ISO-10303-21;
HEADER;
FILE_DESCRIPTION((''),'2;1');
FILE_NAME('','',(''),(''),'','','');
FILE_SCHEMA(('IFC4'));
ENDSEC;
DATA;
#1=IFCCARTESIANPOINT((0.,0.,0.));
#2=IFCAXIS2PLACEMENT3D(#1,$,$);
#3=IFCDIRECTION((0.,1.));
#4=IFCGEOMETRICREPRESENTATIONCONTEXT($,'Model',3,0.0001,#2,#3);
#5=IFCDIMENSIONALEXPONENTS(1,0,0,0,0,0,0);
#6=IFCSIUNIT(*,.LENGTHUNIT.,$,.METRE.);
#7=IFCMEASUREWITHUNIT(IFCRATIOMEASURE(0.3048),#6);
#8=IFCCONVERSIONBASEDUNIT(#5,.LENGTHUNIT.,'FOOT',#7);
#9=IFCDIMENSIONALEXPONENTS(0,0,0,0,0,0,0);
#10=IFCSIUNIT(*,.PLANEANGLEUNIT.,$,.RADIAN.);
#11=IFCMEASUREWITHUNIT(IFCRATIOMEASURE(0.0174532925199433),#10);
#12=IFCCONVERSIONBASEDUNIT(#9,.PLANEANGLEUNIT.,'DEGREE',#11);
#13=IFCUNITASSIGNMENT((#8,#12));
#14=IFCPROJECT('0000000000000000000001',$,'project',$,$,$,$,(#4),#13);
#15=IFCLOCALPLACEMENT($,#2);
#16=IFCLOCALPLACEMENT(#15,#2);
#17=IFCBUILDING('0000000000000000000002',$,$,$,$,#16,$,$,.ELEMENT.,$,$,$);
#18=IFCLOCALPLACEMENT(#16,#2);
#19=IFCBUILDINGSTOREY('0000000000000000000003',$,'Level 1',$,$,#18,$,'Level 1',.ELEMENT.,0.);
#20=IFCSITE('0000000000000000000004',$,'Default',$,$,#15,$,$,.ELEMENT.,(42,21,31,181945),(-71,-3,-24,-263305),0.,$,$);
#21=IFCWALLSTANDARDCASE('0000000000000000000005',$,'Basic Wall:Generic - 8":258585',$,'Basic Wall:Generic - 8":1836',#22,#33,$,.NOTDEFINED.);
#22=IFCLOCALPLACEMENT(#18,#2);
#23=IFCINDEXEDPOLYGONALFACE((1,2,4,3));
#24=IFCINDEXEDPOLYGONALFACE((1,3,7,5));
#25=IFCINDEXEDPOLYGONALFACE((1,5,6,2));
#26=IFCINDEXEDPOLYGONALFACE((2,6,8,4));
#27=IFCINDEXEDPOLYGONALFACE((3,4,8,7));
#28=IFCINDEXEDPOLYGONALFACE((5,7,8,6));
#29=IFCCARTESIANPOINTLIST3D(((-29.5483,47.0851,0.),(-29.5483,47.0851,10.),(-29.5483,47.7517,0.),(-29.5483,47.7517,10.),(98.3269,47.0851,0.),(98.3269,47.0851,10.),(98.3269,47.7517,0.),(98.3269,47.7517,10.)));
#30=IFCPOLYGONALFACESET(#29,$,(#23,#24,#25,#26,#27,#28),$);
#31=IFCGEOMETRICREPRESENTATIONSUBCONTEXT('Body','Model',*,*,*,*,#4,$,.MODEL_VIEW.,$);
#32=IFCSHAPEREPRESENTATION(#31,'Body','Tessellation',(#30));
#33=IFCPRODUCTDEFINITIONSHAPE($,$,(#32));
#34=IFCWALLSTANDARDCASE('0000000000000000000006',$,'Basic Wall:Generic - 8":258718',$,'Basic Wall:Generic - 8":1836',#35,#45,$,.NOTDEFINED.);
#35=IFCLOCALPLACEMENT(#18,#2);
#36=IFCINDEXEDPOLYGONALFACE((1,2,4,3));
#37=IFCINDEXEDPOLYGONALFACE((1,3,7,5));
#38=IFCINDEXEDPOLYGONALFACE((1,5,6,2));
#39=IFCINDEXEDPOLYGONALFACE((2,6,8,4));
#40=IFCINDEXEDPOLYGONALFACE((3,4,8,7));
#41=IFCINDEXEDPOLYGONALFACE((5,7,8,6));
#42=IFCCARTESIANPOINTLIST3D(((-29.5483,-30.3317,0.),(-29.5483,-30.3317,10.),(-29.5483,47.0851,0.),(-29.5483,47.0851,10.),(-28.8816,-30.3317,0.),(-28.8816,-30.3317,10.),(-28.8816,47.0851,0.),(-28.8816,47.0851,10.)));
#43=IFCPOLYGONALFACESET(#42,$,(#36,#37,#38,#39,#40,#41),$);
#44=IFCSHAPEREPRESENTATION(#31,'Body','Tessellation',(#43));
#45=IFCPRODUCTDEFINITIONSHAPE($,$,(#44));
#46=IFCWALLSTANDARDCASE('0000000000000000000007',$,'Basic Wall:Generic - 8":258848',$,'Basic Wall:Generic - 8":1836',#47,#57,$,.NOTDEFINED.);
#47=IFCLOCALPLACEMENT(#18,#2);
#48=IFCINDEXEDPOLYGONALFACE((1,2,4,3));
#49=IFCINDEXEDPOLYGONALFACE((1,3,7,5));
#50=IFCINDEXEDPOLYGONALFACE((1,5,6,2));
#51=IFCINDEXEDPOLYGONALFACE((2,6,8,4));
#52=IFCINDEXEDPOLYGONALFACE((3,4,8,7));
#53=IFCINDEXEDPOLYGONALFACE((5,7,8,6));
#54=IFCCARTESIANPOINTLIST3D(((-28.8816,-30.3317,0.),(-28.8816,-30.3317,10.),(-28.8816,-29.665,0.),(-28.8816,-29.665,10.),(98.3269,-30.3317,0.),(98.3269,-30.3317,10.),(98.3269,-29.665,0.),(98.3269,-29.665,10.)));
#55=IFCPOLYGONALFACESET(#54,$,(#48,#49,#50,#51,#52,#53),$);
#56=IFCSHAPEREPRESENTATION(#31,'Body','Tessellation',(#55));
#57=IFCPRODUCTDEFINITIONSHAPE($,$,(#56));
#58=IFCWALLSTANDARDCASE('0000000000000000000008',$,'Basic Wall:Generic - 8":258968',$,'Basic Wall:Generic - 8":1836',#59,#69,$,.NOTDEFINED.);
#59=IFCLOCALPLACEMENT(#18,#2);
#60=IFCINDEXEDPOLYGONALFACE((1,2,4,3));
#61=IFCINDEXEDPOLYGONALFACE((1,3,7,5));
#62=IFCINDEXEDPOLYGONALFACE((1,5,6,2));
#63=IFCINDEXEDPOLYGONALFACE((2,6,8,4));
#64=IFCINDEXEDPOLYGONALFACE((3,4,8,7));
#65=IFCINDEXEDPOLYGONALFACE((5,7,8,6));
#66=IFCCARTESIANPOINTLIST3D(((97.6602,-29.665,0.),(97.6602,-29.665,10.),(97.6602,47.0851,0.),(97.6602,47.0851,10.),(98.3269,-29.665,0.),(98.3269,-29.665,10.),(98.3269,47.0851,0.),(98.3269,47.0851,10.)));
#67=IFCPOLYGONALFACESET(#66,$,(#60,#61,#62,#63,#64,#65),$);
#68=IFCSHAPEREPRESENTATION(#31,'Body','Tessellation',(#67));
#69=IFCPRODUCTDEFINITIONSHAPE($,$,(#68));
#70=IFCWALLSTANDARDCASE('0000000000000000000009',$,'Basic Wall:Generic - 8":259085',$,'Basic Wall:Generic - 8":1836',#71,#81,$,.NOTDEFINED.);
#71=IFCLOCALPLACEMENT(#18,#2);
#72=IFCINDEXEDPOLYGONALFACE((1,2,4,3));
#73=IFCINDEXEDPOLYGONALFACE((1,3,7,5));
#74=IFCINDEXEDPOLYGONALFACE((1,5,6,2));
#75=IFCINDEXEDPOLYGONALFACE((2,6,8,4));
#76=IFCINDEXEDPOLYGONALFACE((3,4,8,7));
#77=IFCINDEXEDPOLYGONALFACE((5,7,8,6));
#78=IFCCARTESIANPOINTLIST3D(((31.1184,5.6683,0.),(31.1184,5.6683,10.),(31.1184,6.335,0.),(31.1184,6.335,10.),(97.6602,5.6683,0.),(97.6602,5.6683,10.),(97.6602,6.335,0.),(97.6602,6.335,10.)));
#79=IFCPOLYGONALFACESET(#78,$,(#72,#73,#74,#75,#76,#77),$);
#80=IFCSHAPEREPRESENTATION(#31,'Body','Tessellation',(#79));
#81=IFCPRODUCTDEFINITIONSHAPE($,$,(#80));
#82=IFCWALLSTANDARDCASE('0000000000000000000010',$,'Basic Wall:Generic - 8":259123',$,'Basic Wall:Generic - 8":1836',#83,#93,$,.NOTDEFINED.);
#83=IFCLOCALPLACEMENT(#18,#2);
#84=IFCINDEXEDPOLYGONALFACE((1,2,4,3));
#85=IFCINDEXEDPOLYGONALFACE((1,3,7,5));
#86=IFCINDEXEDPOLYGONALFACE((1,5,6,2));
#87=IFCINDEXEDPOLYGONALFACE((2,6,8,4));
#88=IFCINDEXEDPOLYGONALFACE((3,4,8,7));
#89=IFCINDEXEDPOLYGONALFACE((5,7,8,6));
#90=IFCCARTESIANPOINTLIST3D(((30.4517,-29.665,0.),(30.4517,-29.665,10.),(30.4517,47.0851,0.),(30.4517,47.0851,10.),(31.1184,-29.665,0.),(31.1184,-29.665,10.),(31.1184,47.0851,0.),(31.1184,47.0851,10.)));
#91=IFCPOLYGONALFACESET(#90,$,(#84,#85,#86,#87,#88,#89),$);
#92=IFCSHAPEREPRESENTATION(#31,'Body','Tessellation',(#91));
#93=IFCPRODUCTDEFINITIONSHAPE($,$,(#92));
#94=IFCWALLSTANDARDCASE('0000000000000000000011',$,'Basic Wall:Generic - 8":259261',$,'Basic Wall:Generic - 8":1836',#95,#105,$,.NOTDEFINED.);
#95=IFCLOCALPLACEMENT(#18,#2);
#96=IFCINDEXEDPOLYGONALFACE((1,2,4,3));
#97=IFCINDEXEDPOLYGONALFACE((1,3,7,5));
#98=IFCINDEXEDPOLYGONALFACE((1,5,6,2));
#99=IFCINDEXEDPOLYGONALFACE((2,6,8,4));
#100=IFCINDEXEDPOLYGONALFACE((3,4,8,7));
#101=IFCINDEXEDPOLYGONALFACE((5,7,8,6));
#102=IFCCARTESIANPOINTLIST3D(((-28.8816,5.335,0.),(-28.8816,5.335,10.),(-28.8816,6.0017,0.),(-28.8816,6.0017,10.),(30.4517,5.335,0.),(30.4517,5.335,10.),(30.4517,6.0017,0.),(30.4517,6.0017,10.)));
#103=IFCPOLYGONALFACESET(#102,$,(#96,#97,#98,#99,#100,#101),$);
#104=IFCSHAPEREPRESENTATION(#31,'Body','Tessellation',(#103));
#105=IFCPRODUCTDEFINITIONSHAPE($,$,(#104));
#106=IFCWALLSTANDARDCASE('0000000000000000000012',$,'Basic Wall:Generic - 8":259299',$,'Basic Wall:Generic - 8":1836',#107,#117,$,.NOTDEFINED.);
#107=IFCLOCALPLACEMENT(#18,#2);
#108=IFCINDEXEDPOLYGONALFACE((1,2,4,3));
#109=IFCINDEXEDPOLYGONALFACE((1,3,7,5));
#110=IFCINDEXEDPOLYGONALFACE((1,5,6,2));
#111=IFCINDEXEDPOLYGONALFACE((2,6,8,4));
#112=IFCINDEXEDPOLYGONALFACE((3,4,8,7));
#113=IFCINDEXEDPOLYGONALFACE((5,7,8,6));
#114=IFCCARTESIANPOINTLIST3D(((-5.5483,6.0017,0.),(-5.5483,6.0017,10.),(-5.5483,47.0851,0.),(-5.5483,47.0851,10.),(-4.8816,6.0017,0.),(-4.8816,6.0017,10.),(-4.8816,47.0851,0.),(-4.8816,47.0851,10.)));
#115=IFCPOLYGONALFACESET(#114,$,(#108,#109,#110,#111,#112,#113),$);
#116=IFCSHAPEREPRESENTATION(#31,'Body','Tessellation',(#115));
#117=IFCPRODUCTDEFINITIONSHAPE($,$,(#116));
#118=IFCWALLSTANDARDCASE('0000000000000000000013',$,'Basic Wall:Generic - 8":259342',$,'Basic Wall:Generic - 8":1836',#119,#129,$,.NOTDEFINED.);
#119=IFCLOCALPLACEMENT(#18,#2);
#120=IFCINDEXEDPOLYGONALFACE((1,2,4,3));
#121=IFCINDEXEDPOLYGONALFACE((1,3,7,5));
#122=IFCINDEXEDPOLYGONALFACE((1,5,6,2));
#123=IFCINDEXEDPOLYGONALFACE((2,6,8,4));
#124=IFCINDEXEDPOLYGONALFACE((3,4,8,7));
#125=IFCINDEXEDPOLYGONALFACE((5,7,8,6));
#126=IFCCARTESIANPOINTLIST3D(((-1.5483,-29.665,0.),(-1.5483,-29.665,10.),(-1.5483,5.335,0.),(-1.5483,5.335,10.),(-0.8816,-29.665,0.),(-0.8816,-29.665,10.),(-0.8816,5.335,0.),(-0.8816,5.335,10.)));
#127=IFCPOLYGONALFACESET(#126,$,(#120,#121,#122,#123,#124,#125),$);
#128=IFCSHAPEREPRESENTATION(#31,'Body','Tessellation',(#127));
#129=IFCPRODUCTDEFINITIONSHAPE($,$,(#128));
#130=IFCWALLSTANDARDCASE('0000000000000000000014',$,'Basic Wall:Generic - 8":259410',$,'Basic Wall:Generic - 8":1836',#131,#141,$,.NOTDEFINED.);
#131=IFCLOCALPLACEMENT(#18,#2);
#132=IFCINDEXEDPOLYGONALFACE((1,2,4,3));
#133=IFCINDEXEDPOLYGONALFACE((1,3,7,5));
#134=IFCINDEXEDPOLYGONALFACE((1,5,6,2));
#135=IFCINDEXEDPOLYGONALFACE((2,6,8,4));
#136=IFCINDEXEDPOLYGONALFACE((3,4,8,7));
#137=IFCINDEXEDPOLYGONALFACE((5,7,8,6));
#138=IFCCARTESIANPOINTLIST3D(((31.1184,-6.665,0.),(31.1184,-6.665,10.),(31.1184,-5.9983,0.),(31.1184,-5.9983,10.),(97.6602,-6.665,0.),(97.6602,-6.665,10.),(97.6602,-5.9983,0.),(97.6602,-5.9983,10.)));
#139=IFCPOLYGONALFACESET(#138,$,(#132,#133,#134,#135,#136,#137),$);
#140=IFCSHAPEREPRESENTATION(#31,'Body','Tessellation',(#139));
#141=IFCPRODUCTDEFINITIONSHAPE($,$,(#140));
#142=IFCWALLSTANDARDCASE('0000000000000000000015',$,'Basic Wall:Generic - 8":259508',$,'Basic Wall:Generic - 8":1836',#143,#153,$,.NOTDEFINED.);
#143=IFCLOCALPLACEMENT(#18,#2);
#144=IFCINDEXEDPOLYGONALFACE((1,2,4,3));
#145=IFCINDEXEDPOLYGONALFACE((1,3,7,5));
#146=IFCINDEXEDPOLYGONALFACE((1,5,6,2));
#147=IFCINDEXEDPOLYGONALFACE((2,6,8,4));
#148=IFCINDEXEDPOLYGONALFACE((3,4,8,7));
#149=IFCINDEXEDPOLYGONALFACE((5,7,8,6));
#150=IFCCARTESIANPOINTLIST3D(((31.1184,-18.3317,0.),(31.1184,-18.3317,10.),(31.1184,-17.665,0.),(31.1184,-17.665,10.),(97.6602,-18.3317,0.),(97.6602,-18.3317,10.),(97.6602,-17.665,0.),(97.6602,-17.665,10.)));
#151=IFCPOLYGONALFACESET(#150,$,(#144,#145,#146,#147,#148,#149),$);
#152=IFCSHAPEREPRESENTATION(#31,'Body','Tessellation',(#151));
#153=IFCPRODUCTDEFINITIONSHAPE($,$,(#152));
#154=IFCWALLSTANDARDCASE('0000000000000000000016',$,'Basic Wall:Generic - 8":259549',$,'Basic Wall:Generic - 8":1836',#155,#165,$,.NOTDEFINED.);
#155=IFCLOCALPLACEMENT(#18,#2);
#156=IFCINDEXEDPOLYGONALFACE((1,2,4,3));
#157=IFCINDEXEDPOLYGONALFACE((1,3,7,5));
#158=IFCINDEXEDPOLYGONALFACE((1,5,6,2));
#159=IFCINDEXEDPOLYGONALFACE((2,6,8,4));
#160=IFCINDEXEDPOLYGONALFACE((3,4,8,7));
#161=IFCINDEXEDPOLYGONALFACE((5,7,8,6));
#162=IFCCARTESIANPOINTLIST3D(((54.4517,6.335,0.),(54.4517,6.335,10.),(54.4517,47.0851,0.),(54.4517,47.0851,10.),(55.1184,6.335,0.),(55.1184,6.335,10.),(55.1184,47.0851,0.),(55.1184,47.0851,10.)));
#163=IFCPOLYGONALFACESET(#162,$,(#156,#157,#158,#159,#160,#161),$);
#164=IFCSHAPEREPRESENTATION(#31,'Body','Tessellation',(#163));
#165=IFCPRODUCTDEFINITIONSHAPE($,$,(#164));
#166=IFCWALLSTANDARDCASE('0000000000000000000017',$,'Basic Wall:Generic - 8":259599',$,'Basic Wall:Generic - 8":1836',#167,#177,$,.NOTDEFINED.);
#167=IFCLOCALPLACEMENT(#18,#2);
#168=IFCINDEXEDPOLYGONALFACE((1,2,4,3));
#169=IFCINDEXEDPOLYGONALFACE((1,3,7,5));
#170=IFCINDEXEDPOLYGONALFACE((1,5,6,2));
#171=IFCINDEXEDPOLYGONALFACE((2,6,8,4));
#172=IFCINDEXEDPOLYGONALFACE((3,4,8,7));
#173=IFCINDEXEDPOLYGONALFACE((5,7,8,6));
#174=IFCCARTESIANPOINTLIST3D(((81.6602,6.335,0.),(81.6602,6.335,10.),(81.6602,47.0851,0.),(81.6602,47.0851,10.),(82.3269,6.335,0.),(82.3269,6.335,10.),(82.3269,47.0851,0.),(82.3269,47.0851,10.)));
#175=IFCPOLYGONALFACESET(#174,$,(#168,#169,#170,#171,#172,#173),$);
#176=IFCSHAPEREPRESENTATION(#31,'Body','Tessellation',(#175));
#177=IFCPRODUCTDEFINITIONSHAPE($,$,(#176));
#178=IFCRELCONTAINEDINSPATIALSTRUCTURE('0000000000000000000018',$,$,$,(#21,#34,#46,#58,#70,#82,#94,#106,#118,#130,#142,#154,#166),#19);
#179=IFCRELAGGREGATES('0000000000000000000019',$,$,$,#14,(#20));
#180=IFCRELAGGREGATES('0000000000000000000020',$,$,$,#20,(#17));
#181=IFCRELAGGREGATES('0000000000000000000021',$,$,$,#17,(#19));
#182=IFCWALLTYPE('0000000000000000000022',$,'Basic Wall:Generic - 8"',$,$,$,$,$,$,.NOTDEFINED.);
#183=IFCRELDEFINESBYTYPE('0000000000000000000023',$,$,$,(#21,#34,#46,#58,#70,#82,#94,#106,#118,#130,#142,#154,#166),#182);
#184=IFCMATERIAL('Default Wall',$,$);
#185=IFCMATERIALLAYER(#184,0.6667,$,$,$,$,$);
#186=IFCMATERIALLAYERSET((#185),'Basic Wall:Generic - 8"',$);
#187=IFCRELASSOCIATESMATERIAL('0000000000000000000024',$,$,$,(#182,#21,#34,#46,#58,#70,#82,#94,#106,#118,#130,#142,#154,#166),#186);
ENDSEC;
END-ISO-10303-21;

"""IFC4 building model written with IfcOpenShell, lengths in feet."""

from ifc_helpers import new_model, entity, si_unit, converted_unit, direction, frame, frame_2d, origin, place, context, subcontext, project, spatial, rectangle, extrude, material, layer, layer_set, layer_usage, type_object, element, save


model = new_model("IFC4")

# Units and contexts
model_context = context("Model", 3, precision=0.0001, world=origin(), true_north=direction((0.0, 1.0)))
body_context = subcontext(model_context, "Body", "Model", "MODEL_VIEW")
ifc_project = project(units=[converted_unit("LENGTHUNIT", "FOOT", entity("IfcRatioMeasure", 0.3048), si_unit("LENGTHUNIT", "METRE"), dimensions=[1, 0, 0, 0, 0, 0, 0]), converted_unit("PLANEANGLEUNIT", "DEGREE", entity("IfcRatioMeasure", 0.0174532925199433), si_unit("PLANEANGLEUNIT", "RADIAN"), dimensions=[0, 0, 0, 0, 0, 0, 0])], contexts=[model_context])

# Site, building, storey
site_placement = place(None, origin())
site = spatial("IfcSite", under=ifc_project, at=site_placement, Name="Default", CompositionType="ELEMENT", RefLatitude=(42, 21, 31, 181945), RefLongitude=(-71, -3, -24, -263305), RefElevation=0.0)
building_placement = place(site_placement, origin())
building = spatial("IfcBuilding", under=site, at=building_placement, CompositionType="ELEMENT")
storey_placement = place(building_placement, origin())
storey = spatial("IfcBuildingStorey", under=building, at=storey_placement, Name="Level 1", LongName="Level 1", CompositionType="ELEMENT", Elevation=0.0)

# Walls
ifc_material = material(Name="Default Wall")
ifc_layer = layer(ifc_material, 0.6667)
ifc_layer_set = layer_set([ifc_layer], Name="Basic Wall:Generic - 8\"")
ifc_layer_usage_1 = layer_usage(ifc_layer_set, "AXIS2", "NEGATIVE", 0.3333)
wall_type = type_object("IfcWallType", Name="Basic Wall:Generic - 8\"", PredefinedType="NOTDEFINED", material=ifc_layer_set)
wall_1_placement = place(storey_placement, frame((-29.5483, 47.4184, 0.0)))
element("IfcWallStandardCase", 1, at=wall_1_placement, inside=storey, type_object=wall_type, material=ifc_layer_usage_1, Name="Basic Wall:Generic - 8\":258585", ObjectType="Basic Wall:Generic - 8\":1836", PredefinedType="NOTDEFINED", context=body_context, shape_type="SweptSolid", body=[
    extrude(rectangle(XDim=127.8752, YDim=0.6667, at=frame_2d((63.9376, 0.0), x_axis=(-1.0, 0.0))), origin(), (0.0, 0.0, 1.0), 10.0),
])
ifc_layer_usage_2 = layer_usage(ifc_layer_set, "AXIS2", "NEGATIVE", 0.3333)
wall_2_placement = place(storey_placement, frame((-29.215, 47.0851, 0.0), z_axis=(0.0, 0.0, 1.0), x_axis=(0.0, -1.0, 0.0)))
element("IfcWallStandardCase", 2, at=wall_2_placement, inside=storey, type_object=wall_type, material=ifc_layer_usage_2, Name="Basic Wall:Generic - 8\":258718", ObjectType="Basic Wall:Generic - 8\":1836", PredefinedType="NOTDEFINED", context=body_context, shape_type="SweptSolid", body=[
    extrude(rectangle(XDim=77.4167, YDim=0.6667, at=frame_2d((38.7084, 0.0), x_axis=(-1.0, 0.0))), origin(), (0.0, 0.0, 1.0), 10.0),
])
ifc_layer_usage_3 = layer_usage(ifc_layer_set, "AXIS2", "NEGATIVE", 0.3333)
wall_3_placement = place(storey_placement, frame((-28.8816, -29.9983, 0.0)))
element("IfcWallStandardCase", 3, at=wall_3_placement, inside=storey, type_object=wall_type, material=ifc_layer_usage_3, Name="Basic Wall:Generic - 8\":258848", ObjectType="Basic Wall:Generic - 8\":1836", PredefinedType="NOTDEFINED", context=body_context, shape_type="SweptSolid", body=[
    extrude(rectangle(XDim=127.2085, YDim=0.6667, at=frame_2d((63.6043, 0.0), x_axis=(-1.0, 0.0))), origin(), (0.0, 0.0, 1.0), 10.0),
])
ifc_layer_usage_4 = layer_usage(ifc_layer_set, "AXIS2", "NEGATIVE", 0.3333)
wall_4_placement = place(storey_placement, frame((97.9936, -29.665, 0.0), z_axis=(0.0, 0.0, 1.0), x_axis=(0.0, 1.0, 0.0)))
element("IfcWallStandardCase", 4, at=wall_4_placement, inside=storey, type_object=wall_type, material=ifc_layer_usage_4, Name="Basic Wall:Generic - 8\":258968", ObjectType="Basic Wall:Generic - 8\":1836", PredefinedType="NOTDEFINED", context=body_context, shape_type="SweptSolid", body=[
    extrude(rectangle(XDim=76.7501, YDim=0.6667, at=frame_2d((38.375, 0.0), x_axis=(-1.0, 0.0))), origin(), (0.0, 0.0, 1.0), 10.0),
])
ifc_layer_usage_5 = layer_usage(ifc_layer_set, "AXIS2", "NEGATIVE", 0.3333)
wall_5_placement = place(storey_placement, frame((97.6602, 6.0017, 0.0), z_axis=(0.0, 0.0, 1.0), x_axis=(-1.0, 0.0, 0.0)))
element("IfcWallStandardCase", 5, at=wall_5_placement, inside=storey, type_object=wall_type, material=ifc_layer_usage_5, Name="Basic Wall:Generic - 8\":259085", ObjectType="Basic Wall:Generic - 8\":1836", PredefinedType="NOTDEFINED", context=body_context, shape_type="SweptSolid", body=[
    extrude(rectangle(XDim=66.5419, YDim=0.6667, at=frame_2d((33.2709, 0.0), x_axis=(-1.0, 0.0))), origin(), (0.0, 0.0, 1.0), 10.0),
])
ifc_layer_usage_6 = layer_usage(ifc_layer_set, "AXIS2", "NEGATIVE", 0.3333)
wall_6_placement = place(storey_placement, frame((30.785, -29.665, 0.0), z_axis=(0.0, 0.0, 1.0), x_axis=(0.0, 1.0, 0.0)))
element("IfcWallStandardCase", 6, at=wall_6_placement, inside=storey, type_object=wall_type, material=ifc_layer_usage_6, Name="Basic Wall:Generic - 8\":259123", ObjectType="Basic Wall:Generic - 8\":1836", PredefinedType="NOTDEFINED", context=body_context, shape_type="SweptSolid", body=[
    extrude(rectangle(XDim=76.7501, YDim=0.6667, at=frame_2d((38.375, 0.0), x_axis=(-1.0, 0.0))), origin(), (0.0, 0.0, 1.0), 10.0),
])
ifc_layer_usage_7 = layer_usage(ifc_layer_set, "AXIS2", "NEGATIVE", 0.3333)
wall_7_placement = place(storey_placement, frame((30.4517, 5.6683, 0.0), z_axis=(0.0, 0.0, 1.0), x_axis=(-1.0, 0.0, 0.0)))
element("IfcWallStandardCase", 7, at=wall_7_placement, inside=storey, type_object=wall_type, material=ifc_layer_usage_7, Name="Basic Wall:Generic - 8\":259261", ObjectType="Basic Wall:Generic - 8\":1836", PredefinedType="NOTDEFINED", context=body_context, shape_type="SweptSolid", body=[
    extrude(rectangle(XDim=59.3333, YDim=0.6667, at=frame_2d((29.6667, 0.0), x_axis=(-1.0, 0.0))), origin(), (0.0, 0.0, 1.0), 10.0),
])
ifc_layer_usage_8 = layer_usage(ifc_layer_set, "AXIS2", "NEGATIVE", 0.3333)
wall_8_placement = place(storey_placement, frame((-5.215, 47.0851, 0.0), z_axis=(0.0, 0.0, 1.0), x_axis=(0.0, -1.0, 0.0)))
element("IfcWallStandardCase", 8, at=wall_8_placement, inside=storey, type_object=wall_type, material=ifc_layer_usage_8, Name="Basic Wall:Generic - 8\":259299", ObjectType="Basic Wall:Generic - 8\":1836", PredefinedType="NOTDEFINED", context=body_context, shape_type="SweptSolid", body=[
    extrude(rectangle(XDim=41.0834, YDim=0.6667, at=frame_2d((20.5417, 0.0), x_axis=(-1.0, 0.0))), origin(), (0.0, 0.0, 1.0), 10.0),
])
ifc_layer_usage_9 = layer_usage(ifc_layer_set, "AXIS2", "NEGATIVE", 0.3333)
wall_9_placement = place(storey_placement, frame((-1.215, -29.665, 0.0), z_axis=(0.0, 0.0, 1.0), x_axis=(0.0, 1.0, 0.0)))
element("IfcWallStandardCase", 9, at=wall_9_placement, inside=storey, type_object=wall_type, material=ifc_layer_usage_9, Name="Basic Wall:Generic - 8\":259342", ObjectType="Basic Wall:Generic - 8\":1836", PredefinedType="NOTDEFINED", context=body_context, shape_type="SweptSolid", body=[
    extrude(rectangle(XDim=35.0, YDim=0.6667, at=frame_2d((17.5, 0.0), x_axis=(-1.0, 0.0))), origin(), (0.0, 0.0, 1.0), 10.0),
])
ifc_layer_usage_10 = layer_usage(ifc_layer_set, "AXIS2", "NEGATIVE", 0.3333)
wall_10_placement = place(storey_placement, frame((97.6602, -6.3317, 0.0), z_axis=(0.0, 0.0, 1.0), x_axis=(-1.0, 0.0, 0.0)))
element("IfcWallStandardCase", 10, at=wall_10_placement, inside=storey, type_object=wall_type, material=ifc_layer_usage_10, Name="Basic Wall:Generic - 8\":259410", ObjectType="Basic Wall:Generic - 8\":1836", PredefinedType="NOTDEFINED", context=body_context, shape_type="SweptSolid", body=[
    extrude(rectangle(XDim=66.5419, YDim=0.6667, at=frame_2d((33.2709, 0.0), x_axis=(-1.0, 0.0))), origin(), (0.0, 0.0, 1.0), 10.0),
])
ifc_layer_usage_11 = layer_usage(ifc_layer_set, "AXIS2", "NEGATIVE", 0.3333)
wall_11_placement = place(storey_placement, frame((31.1184, -17.9983, 0.0)))
element("IfcWallStandardCase", 11, at=wall_11_placement, inside=storey, type_object=wall_type, material=ifc_layer_usage_11, Name="Basic Wall:Generic - 8\":259508", ObjectType="Basic Wall:Generic - 8\":1836", PredefinedType="NOTDEFINED", context=body_context, shape_type="SweptSolid", body=[
    extrude(rectangle(XDim=66.5419, YDim=0.6667, at=frame_2d((33.2709, 0.0), x_axis=(-1.0, 0.0))), origin(), (0.0, 0.0, 1.0), 10.0),
])
ifc_layer_usage_12 = layer_usage(ifc_layer_set, "AXIS2", "NEGATIVE", 0.3333)
wall_12_placement = place(storey_placement, frame((54.785, 47.0851, 0.0), z_axis=(0.0, 0.0, 1.0), x_axis=(0.0, -1.0, 0.0)))
element("IfcWallStandardCase", 12, at=wall_12_placement, inside=storey, type_object=wall_type, material=ifc_layer_usage_12, Name="Basic Wall:Generic - 8\":259549", ObjectType="Basic Wall:Generic - 8\":1836", PredefinedType="NOTDEFINED", context=body_context, shape_type="SweptSolid", body=[
    extrude(rectangle(XDim=40.7501, YDim=0.6667, at=frame_2d((20.375, 0.0), x_axis=(-1.0, 0.0))), origin(), (0.0, 0.0, 1.0), 10.0),
])
ifc_layer_usage_13 = layer_usage(ifc_layer_set, "AXIS2", "NEGATIVE", 0.3333)
wall_13_placement = place(storey_placement, frame((81.9936, 6.335, 0.0), z_axis=(0.0, 0.0, 1.0), x_axis=(0.0, 1.0, 0.0)))
element("IfcWallStandardCase", 13, at=wall_13_placement, inside=storey, type_object=wall_type, material=ifc_layer_usage_13, Name="Basic Wall:Generic - 8\":259599", ObjectType="Basic Wall:Generic - 8\":1836", PredefinedType="NOTDEFINED", context=body_context, shape_type="SweptSolid", body=[
    extrude(rectangle(XDim=40.7501, YDim=0.6667, at=frame_2d((20.375, 0.0), x_axis=(-1.0, 0.0))), origin(), (0.0, 0.0, 1.0), 10.0),
])

save(model, "model.ifc")
